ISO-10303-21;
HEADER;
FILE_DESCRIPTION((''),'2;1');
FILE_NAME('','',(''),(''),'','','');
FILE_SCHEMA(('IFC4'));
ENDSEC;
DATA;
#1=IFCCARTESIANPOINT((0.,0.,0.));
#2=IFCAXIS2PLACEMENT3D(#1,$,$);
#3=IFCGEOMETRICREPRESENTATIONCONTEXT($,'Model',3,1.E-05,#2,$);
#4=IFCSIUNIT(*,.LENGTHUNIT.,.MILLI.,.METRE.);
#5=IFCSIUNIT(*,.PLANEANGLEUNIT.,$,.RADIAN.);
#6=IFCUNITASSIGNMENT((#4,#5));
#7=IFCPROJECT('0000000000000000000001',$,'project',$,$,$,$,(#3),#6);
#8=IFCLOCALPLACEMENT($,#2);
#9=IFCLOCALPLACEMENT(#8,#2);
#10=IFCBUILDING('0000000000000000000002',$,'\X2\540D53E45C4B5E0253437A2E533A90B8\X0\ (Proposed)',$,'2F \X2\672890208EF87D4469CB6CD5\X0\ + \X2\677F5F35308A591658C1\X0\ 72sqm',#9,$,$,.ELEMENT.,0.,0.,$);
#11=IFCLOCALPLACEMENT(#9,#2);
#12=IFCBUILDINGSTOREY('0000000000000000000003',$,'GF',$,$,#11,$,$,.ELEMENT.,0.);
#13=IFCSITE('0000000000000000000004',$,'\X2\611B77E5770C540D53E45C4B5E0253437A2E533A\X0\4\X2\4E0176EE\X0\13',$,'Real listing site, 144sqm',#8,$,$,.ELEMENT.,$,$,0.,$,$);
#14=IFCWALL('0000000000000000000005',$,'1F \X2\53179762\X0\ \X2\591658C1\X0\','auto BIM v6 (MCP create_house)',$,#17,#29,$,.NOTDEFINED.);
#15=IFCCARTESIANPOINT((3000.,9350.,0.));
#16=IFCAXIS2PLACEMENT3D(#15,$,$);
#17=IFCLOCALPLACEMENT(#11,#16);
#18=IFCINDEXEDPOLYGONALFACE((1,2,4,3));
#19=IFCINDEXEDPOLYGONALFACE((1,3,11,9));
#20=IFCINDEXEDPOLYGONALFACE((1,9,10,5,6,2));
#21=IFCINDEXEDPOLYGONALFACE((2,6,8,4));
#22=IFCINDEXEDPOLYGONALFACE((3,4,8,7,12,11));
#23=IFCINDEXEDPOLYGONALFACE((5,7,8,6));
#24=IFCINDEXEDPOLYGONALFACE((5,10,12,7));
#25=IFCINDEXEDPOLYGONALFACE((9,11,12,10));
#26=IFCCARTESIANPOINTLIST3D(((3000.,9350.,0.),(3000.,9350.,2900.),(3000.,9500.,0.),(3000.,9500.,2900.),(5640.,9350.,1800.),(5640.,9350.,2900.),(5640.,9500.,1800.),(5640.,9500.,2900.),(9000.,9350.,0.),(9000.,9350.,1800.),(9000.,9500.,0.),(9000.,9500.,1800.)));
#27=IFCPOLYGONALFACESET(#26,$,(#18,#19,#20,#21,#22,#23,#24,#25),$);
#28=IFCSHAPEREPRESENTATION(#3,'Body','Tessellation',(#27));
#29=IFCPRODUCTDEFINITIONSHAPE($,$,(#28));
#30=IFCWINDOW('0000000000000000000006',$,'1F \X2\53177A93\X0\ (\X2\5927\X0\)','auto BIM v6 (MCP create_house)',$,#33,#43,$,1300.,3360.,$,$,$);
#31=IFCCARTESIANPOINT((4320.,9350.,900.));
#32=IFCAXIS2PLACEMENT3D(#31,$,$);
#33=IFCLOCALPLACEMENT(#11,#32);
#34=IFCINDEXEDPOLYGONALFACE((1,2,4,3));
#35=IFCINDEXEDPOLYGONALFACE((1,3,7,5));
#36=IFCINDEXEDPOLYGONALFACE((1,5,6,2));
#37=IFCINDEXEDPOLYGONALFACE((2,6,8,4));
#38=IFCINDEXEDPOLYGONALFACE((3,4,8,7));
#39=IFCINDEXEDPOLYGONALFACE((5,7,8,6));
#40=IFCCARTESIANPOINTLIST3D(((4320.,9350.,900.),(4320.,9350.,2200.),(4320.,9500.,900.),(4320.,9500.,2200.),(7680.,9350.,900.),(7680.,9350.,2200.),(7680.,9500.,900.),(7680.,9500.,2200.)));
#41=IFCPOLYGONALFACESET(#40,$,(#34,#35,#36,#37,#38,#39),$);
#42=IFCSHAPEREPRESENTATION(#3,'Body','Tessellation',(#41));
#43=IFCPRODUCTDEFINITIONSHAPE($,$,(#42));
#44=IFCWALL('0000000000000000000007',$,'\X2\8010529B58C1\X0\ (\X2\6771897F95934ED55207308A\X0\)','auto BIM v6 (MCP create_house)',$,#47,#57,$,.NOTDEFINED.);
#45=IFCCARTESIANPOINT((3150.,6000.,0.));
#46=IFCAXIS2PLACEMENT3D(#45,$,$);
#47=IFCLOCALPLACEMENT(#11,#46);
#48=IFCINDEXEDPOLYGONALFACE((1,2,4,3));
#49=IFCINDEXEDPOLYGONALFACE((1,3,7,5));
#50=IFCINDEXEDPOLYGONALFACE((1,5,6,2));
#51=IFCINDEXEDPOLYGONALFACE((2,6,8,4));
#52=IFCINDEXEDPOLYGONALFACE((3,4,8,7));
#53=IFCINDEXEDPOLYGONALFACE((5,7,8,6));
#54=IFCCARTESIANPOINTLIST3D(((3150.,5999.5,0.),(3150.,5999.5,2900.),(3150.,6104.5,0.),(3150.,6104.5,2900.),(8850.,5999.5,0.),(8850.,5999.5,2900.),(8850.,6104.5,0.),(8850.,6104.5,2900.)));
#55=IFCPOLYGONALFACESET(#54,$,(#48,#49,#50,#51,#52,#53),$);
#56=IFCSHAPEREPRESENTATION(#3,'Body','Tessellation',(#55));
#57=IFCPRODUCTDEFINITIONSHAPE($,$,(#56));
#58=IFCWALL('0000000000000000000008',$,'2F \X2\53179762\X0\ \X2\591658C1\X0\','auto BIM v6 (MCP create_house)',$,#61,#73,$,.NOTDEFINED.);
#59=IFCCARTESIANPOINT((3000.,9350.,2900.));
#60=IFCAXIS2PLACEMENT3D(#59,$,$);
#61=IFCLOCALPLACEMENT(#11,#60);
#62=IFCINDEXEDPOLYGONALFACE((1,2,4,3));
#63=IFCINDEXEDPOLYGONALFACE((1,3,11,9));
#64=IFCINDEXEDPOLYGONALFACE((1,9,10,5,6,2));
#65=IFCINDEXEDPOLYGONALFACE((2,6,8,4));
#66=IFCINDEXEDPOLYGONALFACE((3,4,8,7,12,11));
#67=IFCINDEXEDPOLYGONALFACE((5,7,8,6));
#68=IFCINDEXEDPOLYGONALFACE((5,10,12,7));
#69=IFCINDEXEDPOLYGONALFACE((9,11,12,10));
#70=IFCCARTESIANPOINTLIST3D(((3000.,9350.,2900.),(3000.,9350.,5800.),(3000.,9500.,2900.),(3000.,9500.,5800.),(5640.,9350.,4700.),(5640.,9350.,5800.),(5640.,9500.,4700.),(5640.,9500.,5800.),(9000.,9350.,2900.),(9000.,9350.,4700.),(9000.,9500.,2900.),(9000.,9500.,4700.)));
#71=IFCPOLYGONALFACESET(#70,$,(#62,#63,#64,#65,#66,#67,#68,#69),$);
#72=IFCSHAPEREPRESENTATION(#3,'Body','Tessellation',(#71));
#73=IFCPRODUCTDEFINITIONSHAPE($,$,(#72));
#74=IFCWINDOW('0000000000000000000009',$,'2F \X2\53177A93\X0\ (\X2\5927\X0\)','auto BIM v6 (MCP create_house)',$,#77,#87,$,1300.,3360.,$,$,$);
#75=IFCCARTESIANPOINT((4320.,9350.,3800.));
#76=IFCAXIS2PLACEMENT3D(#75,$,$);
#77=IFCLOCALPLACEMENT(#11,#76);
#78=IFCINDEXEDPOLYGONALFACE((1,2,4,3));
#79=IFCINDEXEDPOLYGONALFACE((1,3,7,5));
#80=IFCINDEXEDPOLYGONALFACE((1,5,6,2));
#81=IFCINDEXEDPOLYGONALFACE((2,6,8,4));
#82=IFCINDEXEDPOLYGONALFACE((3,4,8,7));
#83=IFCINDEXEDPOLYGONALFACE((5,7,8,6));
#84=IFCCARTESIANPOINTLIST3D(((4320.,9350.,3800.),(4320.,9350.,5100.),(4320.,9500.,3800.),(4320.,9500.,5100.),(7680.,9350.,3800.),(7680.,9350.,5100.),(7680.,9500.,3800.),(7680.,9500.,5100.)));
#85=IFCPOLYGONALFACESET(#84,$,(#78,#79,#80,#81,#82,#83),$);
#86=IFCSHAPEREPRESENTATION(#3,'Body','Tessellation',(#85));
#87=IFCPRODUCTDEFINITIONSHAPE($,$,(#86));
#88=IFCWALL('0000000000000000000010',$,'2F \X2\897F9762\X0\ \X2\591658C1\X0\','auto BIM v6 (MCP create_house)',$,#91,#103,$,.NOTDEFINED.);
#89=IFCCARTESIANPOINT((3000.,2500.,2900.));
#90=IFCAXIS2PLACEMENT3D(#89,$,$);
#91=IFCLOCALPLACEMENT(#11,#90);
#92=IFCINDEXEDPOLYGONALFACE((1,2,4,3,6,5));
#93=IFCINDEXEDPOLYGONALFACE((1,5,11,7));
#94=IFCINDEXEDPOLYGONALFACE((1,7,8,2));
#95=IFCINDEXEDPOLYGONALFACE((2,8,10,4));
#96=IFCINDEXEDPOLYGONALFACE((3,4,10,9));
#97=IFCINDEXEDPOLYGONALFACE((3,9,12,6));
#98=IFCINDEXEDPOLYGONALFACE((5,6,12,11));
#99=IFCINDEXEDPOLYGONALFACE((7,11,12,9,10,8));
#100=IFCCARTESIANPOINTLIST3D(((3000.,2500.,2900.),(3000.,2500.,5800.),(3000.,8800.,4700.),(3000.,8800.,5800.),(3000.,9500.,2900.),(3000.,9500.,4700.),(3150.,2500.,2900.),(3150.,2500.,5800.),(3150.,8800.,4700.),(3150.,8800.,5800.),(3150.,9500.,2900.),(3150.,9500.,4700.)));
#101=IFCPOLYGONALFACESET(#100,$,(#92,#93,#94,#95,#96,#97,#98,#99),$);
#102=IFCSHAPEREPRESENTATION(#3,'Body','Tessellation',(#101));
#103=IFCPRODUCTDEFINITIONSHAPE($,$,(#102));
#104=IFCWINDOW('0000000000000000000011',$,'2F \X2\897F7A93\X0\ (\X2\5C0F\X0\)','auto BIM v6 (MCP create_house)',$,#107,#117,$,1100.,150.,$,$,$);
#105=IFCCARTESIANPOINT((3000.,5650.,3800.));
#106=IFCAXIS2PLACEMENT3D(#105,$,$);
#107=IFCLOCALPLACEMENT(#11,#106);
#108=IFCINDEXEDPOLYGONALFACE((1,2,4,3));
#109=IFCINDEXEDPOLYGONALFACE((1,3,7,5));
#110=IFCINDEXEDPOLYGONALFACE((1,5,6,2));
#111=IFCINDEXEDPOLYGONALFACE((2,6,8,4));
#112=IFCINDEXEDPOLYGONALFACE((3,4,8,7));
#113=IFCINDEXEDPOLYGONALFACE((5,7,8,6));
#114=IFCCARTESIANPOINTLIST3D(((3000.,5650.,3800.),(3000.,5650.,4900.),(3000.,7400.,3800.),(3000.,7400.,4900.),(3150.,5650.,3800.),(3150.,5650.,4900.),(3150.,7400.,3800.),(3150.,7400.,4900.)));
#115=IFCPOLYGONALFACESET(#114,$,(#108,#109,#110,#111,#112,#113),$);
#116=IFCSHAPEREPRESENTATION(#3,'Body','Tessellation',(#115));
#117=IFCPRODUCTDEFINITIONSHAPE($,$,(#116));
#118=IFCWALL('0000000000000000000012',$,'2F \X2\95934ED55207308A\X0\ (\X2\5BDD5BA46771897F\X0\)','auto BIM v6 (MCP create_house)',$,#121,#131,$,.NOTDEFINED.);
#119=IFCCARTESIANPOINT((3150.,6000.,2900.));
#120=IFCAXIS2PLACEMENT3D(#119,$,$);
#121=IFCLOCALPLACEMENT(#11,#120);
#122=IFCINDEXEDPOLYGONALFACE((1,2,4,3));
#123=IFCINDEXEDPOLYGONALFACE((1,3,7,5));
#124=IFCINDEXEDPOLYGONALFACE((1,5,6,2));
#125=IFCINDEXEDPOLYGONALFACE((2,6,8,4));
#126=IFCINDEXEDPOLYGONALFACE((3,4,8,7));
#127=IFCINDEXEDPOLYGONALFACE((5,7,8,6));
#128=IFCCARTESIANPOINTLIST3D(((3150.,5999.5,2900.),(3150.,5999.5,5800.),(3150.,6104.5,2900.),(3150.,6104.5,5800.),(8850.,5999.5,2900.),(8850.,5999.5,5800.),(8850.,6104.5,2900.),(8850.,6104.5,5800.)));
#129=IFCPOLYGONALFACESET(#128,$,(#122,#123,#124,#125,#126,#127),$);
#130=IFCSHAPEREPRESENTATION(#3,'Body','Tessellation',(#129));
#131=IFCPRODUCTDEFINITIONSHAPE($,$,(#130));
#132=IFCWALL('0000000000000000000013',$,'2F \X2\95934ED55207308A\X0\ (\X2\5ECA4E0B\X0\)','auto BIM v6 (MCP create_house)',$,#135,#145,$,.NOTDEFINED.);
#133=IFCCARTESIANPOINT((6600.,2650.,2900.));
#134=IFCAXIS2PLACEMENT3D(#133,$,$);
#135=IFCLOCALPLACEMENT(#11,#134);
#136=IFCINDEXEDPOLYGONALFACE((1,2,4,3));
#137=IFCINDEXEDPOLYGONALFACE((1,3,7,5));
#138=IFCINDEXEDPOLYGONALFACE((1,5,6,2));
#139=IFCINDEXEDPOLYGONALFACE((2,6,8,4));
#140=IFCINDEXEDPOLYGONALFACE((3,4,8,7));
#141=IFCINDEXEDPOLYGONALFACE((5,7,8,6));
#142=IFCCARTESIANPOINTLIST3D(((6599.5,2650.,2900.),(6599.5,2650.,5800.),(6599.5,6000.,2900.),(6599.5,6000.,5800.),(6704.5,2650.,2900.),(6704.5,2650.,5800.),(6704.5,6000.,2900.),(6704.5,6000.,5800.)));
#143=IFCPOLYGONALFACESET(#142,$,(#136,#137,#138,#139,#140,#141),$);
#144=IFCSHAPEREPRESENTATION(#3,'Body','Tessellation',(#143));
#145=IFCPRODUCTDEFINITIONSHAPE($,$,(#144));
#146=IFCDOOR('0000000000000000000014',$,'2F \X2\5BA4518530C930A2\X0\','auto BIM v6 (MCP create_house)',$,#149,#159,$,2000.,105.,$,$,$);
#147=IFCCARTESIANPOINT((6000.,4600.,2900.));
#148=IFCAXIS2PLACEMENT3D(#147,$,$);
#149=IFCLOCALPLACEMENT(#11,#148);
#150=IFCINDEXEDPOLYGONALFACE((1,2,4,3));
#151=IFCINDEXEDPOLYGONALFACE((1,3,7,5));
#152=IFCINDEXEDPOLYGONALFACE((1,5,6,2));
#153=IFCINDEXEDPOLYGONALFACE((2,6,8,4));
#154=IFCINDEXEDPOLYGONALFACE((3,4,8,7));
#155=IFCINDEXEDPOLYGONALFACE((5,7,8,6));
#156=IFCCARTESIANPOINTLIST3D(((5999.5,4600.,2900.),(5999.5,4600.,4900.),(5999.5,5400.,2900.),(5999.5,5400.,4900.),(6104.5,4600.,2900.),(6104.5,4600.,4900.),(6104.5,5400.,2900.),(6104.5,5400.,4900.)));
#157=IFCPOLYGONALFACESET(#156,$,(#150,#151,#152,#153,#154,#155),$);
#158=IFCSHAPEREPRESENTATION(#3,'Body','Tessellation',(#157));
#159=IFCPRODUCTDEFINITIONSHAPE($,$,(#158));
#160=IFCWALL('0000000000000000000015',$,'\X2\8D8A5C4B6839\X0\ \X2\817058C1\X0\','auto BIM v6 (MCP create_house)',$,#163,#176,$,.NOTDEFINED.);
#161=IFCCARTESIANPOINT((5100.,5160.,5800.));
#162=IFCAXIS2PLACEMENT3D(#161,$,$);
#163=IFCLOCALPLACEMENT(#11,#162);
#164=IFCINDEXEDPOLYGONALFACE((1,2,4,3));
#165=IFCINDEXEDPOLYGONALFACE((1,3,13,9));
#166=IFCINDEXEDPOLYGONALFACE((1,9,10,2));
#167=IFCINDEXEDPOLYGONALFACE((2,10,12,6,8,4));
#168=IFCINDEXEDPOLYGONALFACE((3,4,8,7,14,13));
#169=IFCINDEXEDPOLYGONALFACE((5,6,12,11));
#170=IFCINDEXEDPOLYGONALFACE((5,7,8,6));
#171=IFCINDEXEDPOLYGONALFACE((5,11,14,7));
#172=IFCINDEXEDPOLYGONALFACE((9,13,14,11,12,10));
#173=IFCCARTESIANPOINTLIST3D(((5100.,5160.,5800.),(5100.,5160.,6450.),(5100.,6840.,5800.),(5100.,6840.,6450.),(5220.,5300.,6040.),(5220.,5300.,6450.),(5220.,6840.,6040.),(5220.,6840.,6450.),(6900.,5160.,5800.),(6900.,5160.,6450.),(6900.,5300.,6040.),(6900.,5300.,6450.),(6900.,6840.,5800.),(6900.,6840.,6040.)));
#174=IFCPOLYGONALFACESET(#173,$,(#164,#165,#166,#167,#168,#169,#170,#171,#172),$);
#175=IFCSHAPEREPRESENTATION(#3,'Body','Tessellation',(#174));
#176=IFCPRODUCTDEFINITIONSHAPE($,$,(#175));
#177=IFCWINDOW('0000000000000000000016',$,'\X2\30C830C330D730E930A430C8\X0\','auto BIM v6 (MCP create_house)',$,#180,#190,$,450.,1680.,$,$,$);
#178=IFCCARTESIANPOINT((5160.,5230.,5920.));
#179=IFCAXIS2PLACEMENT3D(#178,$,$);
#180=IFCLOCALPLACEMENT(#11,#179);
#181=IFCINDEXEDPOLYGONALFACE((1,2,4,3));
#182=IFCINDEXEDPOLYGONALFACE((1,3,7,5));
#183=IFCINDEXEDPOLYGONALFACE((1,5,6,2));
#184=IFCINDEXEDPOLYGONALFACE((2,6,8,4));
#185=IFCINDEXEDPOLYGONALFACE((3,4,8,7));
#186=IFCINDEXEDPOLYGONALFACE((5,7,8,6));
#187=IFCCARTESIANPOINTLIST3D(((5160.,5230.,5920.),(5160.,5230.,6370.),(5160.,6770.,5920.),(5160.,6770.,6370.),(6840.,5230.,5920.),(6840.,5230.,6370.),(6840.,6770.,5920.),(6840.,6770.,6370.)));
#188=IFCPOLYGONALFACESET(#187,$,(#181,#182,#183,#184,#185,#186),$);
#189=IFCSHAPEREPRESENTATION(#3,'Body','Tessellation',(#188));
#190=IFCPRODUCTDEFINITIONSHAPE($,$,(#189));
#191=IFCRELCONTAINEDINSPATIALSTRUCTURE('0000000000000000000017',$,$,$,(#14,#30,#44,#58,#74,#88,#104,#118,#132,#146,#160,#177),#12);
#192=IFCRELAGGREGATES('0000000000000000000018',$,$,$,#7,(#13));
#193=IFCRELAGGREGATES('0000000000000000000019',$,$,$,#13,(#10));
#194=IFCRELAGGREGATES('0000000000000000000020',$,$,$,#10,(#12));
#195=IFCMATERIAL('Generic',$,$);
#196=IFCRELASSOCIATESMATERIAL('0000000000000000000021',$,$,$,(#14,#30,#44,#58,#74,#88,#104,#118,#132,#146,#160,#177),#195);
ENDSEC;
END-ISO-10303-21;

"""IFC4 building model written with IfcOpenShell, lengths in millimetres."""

from ifc_helpers import new_model, si_unit, frame, frame_2d, origin, place, context, project, spatial, rectangle, extrude, material, element, fill, save


model = new_model("IFC4")

# Units and contexts
model_context = context("Model", 3, precision=1e-05, world=origin())
ifc_project = project(units=[si_unit("LENGTHUNIT", "METRE", prefix="MILLI"), si_unit("PLANEANGLEUNIT", "RADIAN")], contexts=[model_context])

# Site, building, storey
site_placement = place(None, origin())
site = spatial("IfcSite", under=ifc_project, at=site_placement, Name="愛知県名古屋市千種区4丁目13", ObjectType="Real listing site, 144sqm", CompositionType="ELEMENT", RefElevation=0.0)
building_placement = place(site_placement, origin())
building = spatial("IfcBuilding", under=site, at=building_placement, Name="名古屋市千種区邸 (Proposed)", ObjectType="2F 木造軸組構法 + 板張り外壁 72sqm", CompositionType="ELEMENT", ElevationOfRefHeight=0.0, ElevationOfTerrain=0.0)
storey_placement = place(building_placement, origin())
storey = spatial("IfcBuildingStorey", under=building, at=storey_placement, Name="GF", CompositionType="ELEMENT", Elevation=0.0)

# Wall, opening, window
ifc_material = material(Name="Generic")
wall_1_placement = place(storey_placement, frame((3000.0, 9350.0, 0.0)))
wall_1 = element("IfcWall", 1, at=wall_1_placement, inside=storey, material=ifc_material, Name="1F 北面 外壁", Description="auto BIM v6 (MCP create_house)", PredefinedType="NOTDEFINED", context=model_context, shape_type="SweptSolid", body=[
    extrude(rectangle(XDim=6000.0, YDim=150.0, at=frame_2d((3000.0, 75.0))), frame((3000.0, 9350.0, 0.0)), (0.0, 0.0, 1.0), 2900.0),
])
opening_1_placement = place(storey_placement, frame((4320.0, 9350.0, 900.0)))
opening_1 = element("IfcOpeningElement", 2, at=opening_1_placement, cuts=wall_1, PredefinedType="NOTDEFINED", context=model_context, shape_type="SweptSolid", body=[
    extrude(rectangle(XDim=3360.0, YDim=150.0, at=frame_2d((1680.0, 75.0))), frame((4320.0, 9350.0, 900.0)), (0.0, 0.0, 1.0), 1300.0),
])
window_1_placement = place(storey_placement, frame((4320.0, 9350.0, 900.0)))
window_1 = element("IfcWindow", 3, at=window_1_placement, inside=storey, material=ifc_material, Name="1F 北窓 (大)", Description="auto BIM v6 (MCP create_house)", OverallHeight=1300.0, OverallWidth=3360.0, context=model_context, shape_type="SweptSolid", body=[
    extrude(rectangle(XDim=3360.0, YDim=150.0, at=frame_2d((1680.0, 75.0))), frame((4320.0, 9350.0, 900.0)), (0.0, 0.0, 1.0), 1300.0),
])
fill(opening_1, window_1)

# Wall
wall_2_placement = place(storey_placement, frame((3150.0, 6000.0, 0.0)))
element("IfcWall", 4, at=wall_2_placement, inside=storey, material=ifc_material, Name="耐力壁 (東西間仕切り)", Description="auto BIM v6 (MCP create_house)", PredefinedType="NOTDEFINED", context=model_context, shape_type="SweptSolid", body=[
    extrude(rectangle(XDim=5700.0, YDim=105.0, at=frame_2d((2850.0, 52.0))), frame((3150.0, 6000.0, 0.0)), (0.0, 0.0, 1.0), 2900.0),
])

# Walls, openings, windows
wall_3_placement = place(storey_placement, frame((3000.0, 9350.0, 2900.0)))
wall_3 = element("IfcWall", 5, at=wall_3_placement, inside=storey, material=ifc_material, Name="2F 北面 外壁", Description="auto BIM v6 (MCP create_house)", PredefinedType="NOTDEFINED", context=model_context, shape_type="SweptSolid", body=[
    extrude(rectangle(XDim=6000.0, YDim=150.0, at=frame_2d((3000.0, 75.0))), frame((3000.0, 9350.0, 2900.0)), (0.0, 0.0, 1.0), 2900.0),
])
opening_2_placement = place(storey_placement, frame((4320.0, 9350.0, 3800.0)))
opening_2 = element("IfcOpeningElement", 6, at=opening_2_placement, cuts=wall_3, PredefinedType="NOTDEFINED", context=model_context, shape_type="SweptSolid", body=[
    extrude(rectangle(XDim=3360.0, YDim=150.0, at=frame_2d((1680.0, 75.0))), frame((4320.0, 9350.0, 3800.0)), (0.0, 0.0, 1.0), 1300.0),
])
window_2_placement = place(storey_placement, frame((4320.0, 9350.0, 3800.0)))
window_2 = element("IfcWindow", 7, at=window_2_placement, inside=storey, material=ifc_material, Name="2F 北窓 (大)", Description="auto BIM v6 (MCP create_house)", OverallHeight=1300.0, OverallWidth=3360.0, context=model_context, shape_type="SweptSolid", body=[
    extrude(rectangle(XDim=3360.0, YDim=150.0, at=frame_2d((1680.0, 75.0))), frame((4320.0, 9350.0, 3800.0)), (0.0, 0.0, 1.0), 1300.0),
])
fill(opening_2, window_2)
wall_4_placement = place(storey_placement, frame((3000.0, 2500.0, 2900.0)))
wall_4 = element("IfcWall", 8, at=wall_4_placement, inside=storey, material=ifc_material, Name="2F 西面 外壁", Description="auto BIM v6 (MCP create_house)", PredefinedType="NOTDEFINED", context=model_context, shape_type="SweptSolid", body=[
    extrude(rectangle(XDim=150.0, YDim=7000.0, at=frame_2d((75.0, 3500.0))), frame((3000.0, 2500.0, 2900.0)), (0.0, 0.0, 1.0), 2900.0),
])
opening_3_placement = place(storey_placement, frame((3000.0, 5650.0, 3800.0)))
opening_3 = element("IfcOpeningElement", 9, at=opening_3_placement, cuts=wall_4, PredefinedType="NOTDEFINED", context=model_context, shape_type="SweptSolid", body=[
    extrude(rectangle(XDim=150.0, YDim=1750.0, at=frame_2d((75.0, 875.0))), frame((3000.0, 5650.0, 3800.0)), (0.0, 0.0, 1.0), 1100.0),
])
window_3_placement = place(storey_placement, frame((3000.0, 5650.0, 3800.0)))
window_3 = element("IfcWindow", 10, at=window_3_placement, inside=storey, material=ifc_material, Name="2F 西窓 (小)", Description="auto BIM v6 (MCP create_house)", OverallHeight=1100.0, OverallWidth=150.0, context=model_context, shape_type="SweptSolid", body=[
    extrude(rectangle(XDim=150.0, YDim=1750.0, at=frame_2d((75.0, 875.0))), frame((3000.0, 5650.0, 3800.0)), (0.0, 0.0, 1.0), 1100.0),
])
fill(opening_3, window_3)

# Walls
wall_5_placement = place(storey_placement, frame((3150.0, 6000.0, 2900.0)))
element("IfcWall", 11, at=wall_5_placement, inside=storey, material=ifc_material, Name="2F 間仕切り (寝室東西)", Description="auto BIM v6 (MCP create_house)", PredefinedType="NOTDEFINED", context=model_context, shape_type="SweptSolid", body=[
    extrude(rectangle(XDim=5700.0, YDim=105.0, at=frame_2d((2850.0, 52.0))), frame((3150.0, 6000.0, 2900.0)), (0.0, 0.0, 1.0), 2900.0),
])
wall_6_placement = place(storey_placement, frame((6600.0, 2650.0, 2900.0)))
element("IfcWall", 12, at=wall_6_placement, inside=storey, material=ifc_material, Name="2F 間仕切り (廊下)", Description="auto BIM v6 (MCP create_house)", PredefinedType="NOTDEFINED", context=model_context, shape_type="SweptSolid", body=[
    extrude(rectangle(XDim=105.0, YDim=3350.0, at=frame_2d((52.0, 1675.0))), frame((6600.0, 2650.0, 2900.0)), (0.0, 0.0, 1.0), 2900.0),
])

# Door
door_placement = place(storey_placement, frame((6000.0, 4600.0, 2900.0)))
element("IfcDoor", 13, at=door_placement, inside=storey, material=ifc_material, Name="2F 室内ドア", Description="auto BIM v6 (MCP create_house)", OverallHeight=2000.0, OverallWidth=105.0, context=model_context, shape_type="SweptSolid", body=[
    extrude(rectangle(XDim=105.0, YDim=800.0, at=frame_2d((52.0, 400.0))), frame((6000.0, 4600.0, 2900.0)), (0.0, 0.0, 1.0), 2000.0),
])

# Wall, opening, window
wall_7_placement = place(storey_placement, frame((5100.0, 5160.0, 5800.0)))
wall_7 = element("IfcWall", 14, at=wall_7_placement, inside=storey, material=ifc_material, Name="越屋根 腰壁", Description="auto BIM v6 (MCP create_house)", PredefinedType="NOTDEFINED", context=model_context, shape_type="SweptSolid", body=[
    extrude(rectangle(XDim=1800.0, YDim=1680.0, at=frame_2d((900.0, 840.0))), frame((5100.0, 5160.0, 5800.0)), (0.0, 0.0, 1.0), 650.0),
])
opening_4_placement = place(storey_placement, frame((5160.0, 5230.0, 5920.0)))
opening_4 = element("IfcOpeningElement", 15, at=opening_4_placement, cuts=wall_7, PredefinedType="NOTDEFINED", context=model_context, shape_type="SweptSolid", body=[
    extrude(rectangle(XDim=1680.0, YDim=1540.0, at=frame_2d((840.0, 770.0))), frame((5160.0, 5230.0, 5920.0)), (0.0, 0.0, 1.0), 450.0),
])
window_4_placement = place(storey_placement, frame((5160.0, 5230.0, 5920.0)))
window_4 = element("IfcWindow", 16, at=window_4_placement, inside=storey, material=ifc_material, Name="トップライト", Description="auto BIM v6 (MCP create_house)", OverallHeight=450.0, OverallWidth=1680.0, context=model_context, shape_type="SweptSolid", body=[
    extrude(rectangle(XDim=1680.0, YDim=1540.0, at=frame_2d((840.0, 770.0))), frame((5160.0, 5230.0, 5920.0)), (0.0, 0.0, 1.0), 450.0),
])
fill(opening_4, window_4)

save(model, "model.ifc")
